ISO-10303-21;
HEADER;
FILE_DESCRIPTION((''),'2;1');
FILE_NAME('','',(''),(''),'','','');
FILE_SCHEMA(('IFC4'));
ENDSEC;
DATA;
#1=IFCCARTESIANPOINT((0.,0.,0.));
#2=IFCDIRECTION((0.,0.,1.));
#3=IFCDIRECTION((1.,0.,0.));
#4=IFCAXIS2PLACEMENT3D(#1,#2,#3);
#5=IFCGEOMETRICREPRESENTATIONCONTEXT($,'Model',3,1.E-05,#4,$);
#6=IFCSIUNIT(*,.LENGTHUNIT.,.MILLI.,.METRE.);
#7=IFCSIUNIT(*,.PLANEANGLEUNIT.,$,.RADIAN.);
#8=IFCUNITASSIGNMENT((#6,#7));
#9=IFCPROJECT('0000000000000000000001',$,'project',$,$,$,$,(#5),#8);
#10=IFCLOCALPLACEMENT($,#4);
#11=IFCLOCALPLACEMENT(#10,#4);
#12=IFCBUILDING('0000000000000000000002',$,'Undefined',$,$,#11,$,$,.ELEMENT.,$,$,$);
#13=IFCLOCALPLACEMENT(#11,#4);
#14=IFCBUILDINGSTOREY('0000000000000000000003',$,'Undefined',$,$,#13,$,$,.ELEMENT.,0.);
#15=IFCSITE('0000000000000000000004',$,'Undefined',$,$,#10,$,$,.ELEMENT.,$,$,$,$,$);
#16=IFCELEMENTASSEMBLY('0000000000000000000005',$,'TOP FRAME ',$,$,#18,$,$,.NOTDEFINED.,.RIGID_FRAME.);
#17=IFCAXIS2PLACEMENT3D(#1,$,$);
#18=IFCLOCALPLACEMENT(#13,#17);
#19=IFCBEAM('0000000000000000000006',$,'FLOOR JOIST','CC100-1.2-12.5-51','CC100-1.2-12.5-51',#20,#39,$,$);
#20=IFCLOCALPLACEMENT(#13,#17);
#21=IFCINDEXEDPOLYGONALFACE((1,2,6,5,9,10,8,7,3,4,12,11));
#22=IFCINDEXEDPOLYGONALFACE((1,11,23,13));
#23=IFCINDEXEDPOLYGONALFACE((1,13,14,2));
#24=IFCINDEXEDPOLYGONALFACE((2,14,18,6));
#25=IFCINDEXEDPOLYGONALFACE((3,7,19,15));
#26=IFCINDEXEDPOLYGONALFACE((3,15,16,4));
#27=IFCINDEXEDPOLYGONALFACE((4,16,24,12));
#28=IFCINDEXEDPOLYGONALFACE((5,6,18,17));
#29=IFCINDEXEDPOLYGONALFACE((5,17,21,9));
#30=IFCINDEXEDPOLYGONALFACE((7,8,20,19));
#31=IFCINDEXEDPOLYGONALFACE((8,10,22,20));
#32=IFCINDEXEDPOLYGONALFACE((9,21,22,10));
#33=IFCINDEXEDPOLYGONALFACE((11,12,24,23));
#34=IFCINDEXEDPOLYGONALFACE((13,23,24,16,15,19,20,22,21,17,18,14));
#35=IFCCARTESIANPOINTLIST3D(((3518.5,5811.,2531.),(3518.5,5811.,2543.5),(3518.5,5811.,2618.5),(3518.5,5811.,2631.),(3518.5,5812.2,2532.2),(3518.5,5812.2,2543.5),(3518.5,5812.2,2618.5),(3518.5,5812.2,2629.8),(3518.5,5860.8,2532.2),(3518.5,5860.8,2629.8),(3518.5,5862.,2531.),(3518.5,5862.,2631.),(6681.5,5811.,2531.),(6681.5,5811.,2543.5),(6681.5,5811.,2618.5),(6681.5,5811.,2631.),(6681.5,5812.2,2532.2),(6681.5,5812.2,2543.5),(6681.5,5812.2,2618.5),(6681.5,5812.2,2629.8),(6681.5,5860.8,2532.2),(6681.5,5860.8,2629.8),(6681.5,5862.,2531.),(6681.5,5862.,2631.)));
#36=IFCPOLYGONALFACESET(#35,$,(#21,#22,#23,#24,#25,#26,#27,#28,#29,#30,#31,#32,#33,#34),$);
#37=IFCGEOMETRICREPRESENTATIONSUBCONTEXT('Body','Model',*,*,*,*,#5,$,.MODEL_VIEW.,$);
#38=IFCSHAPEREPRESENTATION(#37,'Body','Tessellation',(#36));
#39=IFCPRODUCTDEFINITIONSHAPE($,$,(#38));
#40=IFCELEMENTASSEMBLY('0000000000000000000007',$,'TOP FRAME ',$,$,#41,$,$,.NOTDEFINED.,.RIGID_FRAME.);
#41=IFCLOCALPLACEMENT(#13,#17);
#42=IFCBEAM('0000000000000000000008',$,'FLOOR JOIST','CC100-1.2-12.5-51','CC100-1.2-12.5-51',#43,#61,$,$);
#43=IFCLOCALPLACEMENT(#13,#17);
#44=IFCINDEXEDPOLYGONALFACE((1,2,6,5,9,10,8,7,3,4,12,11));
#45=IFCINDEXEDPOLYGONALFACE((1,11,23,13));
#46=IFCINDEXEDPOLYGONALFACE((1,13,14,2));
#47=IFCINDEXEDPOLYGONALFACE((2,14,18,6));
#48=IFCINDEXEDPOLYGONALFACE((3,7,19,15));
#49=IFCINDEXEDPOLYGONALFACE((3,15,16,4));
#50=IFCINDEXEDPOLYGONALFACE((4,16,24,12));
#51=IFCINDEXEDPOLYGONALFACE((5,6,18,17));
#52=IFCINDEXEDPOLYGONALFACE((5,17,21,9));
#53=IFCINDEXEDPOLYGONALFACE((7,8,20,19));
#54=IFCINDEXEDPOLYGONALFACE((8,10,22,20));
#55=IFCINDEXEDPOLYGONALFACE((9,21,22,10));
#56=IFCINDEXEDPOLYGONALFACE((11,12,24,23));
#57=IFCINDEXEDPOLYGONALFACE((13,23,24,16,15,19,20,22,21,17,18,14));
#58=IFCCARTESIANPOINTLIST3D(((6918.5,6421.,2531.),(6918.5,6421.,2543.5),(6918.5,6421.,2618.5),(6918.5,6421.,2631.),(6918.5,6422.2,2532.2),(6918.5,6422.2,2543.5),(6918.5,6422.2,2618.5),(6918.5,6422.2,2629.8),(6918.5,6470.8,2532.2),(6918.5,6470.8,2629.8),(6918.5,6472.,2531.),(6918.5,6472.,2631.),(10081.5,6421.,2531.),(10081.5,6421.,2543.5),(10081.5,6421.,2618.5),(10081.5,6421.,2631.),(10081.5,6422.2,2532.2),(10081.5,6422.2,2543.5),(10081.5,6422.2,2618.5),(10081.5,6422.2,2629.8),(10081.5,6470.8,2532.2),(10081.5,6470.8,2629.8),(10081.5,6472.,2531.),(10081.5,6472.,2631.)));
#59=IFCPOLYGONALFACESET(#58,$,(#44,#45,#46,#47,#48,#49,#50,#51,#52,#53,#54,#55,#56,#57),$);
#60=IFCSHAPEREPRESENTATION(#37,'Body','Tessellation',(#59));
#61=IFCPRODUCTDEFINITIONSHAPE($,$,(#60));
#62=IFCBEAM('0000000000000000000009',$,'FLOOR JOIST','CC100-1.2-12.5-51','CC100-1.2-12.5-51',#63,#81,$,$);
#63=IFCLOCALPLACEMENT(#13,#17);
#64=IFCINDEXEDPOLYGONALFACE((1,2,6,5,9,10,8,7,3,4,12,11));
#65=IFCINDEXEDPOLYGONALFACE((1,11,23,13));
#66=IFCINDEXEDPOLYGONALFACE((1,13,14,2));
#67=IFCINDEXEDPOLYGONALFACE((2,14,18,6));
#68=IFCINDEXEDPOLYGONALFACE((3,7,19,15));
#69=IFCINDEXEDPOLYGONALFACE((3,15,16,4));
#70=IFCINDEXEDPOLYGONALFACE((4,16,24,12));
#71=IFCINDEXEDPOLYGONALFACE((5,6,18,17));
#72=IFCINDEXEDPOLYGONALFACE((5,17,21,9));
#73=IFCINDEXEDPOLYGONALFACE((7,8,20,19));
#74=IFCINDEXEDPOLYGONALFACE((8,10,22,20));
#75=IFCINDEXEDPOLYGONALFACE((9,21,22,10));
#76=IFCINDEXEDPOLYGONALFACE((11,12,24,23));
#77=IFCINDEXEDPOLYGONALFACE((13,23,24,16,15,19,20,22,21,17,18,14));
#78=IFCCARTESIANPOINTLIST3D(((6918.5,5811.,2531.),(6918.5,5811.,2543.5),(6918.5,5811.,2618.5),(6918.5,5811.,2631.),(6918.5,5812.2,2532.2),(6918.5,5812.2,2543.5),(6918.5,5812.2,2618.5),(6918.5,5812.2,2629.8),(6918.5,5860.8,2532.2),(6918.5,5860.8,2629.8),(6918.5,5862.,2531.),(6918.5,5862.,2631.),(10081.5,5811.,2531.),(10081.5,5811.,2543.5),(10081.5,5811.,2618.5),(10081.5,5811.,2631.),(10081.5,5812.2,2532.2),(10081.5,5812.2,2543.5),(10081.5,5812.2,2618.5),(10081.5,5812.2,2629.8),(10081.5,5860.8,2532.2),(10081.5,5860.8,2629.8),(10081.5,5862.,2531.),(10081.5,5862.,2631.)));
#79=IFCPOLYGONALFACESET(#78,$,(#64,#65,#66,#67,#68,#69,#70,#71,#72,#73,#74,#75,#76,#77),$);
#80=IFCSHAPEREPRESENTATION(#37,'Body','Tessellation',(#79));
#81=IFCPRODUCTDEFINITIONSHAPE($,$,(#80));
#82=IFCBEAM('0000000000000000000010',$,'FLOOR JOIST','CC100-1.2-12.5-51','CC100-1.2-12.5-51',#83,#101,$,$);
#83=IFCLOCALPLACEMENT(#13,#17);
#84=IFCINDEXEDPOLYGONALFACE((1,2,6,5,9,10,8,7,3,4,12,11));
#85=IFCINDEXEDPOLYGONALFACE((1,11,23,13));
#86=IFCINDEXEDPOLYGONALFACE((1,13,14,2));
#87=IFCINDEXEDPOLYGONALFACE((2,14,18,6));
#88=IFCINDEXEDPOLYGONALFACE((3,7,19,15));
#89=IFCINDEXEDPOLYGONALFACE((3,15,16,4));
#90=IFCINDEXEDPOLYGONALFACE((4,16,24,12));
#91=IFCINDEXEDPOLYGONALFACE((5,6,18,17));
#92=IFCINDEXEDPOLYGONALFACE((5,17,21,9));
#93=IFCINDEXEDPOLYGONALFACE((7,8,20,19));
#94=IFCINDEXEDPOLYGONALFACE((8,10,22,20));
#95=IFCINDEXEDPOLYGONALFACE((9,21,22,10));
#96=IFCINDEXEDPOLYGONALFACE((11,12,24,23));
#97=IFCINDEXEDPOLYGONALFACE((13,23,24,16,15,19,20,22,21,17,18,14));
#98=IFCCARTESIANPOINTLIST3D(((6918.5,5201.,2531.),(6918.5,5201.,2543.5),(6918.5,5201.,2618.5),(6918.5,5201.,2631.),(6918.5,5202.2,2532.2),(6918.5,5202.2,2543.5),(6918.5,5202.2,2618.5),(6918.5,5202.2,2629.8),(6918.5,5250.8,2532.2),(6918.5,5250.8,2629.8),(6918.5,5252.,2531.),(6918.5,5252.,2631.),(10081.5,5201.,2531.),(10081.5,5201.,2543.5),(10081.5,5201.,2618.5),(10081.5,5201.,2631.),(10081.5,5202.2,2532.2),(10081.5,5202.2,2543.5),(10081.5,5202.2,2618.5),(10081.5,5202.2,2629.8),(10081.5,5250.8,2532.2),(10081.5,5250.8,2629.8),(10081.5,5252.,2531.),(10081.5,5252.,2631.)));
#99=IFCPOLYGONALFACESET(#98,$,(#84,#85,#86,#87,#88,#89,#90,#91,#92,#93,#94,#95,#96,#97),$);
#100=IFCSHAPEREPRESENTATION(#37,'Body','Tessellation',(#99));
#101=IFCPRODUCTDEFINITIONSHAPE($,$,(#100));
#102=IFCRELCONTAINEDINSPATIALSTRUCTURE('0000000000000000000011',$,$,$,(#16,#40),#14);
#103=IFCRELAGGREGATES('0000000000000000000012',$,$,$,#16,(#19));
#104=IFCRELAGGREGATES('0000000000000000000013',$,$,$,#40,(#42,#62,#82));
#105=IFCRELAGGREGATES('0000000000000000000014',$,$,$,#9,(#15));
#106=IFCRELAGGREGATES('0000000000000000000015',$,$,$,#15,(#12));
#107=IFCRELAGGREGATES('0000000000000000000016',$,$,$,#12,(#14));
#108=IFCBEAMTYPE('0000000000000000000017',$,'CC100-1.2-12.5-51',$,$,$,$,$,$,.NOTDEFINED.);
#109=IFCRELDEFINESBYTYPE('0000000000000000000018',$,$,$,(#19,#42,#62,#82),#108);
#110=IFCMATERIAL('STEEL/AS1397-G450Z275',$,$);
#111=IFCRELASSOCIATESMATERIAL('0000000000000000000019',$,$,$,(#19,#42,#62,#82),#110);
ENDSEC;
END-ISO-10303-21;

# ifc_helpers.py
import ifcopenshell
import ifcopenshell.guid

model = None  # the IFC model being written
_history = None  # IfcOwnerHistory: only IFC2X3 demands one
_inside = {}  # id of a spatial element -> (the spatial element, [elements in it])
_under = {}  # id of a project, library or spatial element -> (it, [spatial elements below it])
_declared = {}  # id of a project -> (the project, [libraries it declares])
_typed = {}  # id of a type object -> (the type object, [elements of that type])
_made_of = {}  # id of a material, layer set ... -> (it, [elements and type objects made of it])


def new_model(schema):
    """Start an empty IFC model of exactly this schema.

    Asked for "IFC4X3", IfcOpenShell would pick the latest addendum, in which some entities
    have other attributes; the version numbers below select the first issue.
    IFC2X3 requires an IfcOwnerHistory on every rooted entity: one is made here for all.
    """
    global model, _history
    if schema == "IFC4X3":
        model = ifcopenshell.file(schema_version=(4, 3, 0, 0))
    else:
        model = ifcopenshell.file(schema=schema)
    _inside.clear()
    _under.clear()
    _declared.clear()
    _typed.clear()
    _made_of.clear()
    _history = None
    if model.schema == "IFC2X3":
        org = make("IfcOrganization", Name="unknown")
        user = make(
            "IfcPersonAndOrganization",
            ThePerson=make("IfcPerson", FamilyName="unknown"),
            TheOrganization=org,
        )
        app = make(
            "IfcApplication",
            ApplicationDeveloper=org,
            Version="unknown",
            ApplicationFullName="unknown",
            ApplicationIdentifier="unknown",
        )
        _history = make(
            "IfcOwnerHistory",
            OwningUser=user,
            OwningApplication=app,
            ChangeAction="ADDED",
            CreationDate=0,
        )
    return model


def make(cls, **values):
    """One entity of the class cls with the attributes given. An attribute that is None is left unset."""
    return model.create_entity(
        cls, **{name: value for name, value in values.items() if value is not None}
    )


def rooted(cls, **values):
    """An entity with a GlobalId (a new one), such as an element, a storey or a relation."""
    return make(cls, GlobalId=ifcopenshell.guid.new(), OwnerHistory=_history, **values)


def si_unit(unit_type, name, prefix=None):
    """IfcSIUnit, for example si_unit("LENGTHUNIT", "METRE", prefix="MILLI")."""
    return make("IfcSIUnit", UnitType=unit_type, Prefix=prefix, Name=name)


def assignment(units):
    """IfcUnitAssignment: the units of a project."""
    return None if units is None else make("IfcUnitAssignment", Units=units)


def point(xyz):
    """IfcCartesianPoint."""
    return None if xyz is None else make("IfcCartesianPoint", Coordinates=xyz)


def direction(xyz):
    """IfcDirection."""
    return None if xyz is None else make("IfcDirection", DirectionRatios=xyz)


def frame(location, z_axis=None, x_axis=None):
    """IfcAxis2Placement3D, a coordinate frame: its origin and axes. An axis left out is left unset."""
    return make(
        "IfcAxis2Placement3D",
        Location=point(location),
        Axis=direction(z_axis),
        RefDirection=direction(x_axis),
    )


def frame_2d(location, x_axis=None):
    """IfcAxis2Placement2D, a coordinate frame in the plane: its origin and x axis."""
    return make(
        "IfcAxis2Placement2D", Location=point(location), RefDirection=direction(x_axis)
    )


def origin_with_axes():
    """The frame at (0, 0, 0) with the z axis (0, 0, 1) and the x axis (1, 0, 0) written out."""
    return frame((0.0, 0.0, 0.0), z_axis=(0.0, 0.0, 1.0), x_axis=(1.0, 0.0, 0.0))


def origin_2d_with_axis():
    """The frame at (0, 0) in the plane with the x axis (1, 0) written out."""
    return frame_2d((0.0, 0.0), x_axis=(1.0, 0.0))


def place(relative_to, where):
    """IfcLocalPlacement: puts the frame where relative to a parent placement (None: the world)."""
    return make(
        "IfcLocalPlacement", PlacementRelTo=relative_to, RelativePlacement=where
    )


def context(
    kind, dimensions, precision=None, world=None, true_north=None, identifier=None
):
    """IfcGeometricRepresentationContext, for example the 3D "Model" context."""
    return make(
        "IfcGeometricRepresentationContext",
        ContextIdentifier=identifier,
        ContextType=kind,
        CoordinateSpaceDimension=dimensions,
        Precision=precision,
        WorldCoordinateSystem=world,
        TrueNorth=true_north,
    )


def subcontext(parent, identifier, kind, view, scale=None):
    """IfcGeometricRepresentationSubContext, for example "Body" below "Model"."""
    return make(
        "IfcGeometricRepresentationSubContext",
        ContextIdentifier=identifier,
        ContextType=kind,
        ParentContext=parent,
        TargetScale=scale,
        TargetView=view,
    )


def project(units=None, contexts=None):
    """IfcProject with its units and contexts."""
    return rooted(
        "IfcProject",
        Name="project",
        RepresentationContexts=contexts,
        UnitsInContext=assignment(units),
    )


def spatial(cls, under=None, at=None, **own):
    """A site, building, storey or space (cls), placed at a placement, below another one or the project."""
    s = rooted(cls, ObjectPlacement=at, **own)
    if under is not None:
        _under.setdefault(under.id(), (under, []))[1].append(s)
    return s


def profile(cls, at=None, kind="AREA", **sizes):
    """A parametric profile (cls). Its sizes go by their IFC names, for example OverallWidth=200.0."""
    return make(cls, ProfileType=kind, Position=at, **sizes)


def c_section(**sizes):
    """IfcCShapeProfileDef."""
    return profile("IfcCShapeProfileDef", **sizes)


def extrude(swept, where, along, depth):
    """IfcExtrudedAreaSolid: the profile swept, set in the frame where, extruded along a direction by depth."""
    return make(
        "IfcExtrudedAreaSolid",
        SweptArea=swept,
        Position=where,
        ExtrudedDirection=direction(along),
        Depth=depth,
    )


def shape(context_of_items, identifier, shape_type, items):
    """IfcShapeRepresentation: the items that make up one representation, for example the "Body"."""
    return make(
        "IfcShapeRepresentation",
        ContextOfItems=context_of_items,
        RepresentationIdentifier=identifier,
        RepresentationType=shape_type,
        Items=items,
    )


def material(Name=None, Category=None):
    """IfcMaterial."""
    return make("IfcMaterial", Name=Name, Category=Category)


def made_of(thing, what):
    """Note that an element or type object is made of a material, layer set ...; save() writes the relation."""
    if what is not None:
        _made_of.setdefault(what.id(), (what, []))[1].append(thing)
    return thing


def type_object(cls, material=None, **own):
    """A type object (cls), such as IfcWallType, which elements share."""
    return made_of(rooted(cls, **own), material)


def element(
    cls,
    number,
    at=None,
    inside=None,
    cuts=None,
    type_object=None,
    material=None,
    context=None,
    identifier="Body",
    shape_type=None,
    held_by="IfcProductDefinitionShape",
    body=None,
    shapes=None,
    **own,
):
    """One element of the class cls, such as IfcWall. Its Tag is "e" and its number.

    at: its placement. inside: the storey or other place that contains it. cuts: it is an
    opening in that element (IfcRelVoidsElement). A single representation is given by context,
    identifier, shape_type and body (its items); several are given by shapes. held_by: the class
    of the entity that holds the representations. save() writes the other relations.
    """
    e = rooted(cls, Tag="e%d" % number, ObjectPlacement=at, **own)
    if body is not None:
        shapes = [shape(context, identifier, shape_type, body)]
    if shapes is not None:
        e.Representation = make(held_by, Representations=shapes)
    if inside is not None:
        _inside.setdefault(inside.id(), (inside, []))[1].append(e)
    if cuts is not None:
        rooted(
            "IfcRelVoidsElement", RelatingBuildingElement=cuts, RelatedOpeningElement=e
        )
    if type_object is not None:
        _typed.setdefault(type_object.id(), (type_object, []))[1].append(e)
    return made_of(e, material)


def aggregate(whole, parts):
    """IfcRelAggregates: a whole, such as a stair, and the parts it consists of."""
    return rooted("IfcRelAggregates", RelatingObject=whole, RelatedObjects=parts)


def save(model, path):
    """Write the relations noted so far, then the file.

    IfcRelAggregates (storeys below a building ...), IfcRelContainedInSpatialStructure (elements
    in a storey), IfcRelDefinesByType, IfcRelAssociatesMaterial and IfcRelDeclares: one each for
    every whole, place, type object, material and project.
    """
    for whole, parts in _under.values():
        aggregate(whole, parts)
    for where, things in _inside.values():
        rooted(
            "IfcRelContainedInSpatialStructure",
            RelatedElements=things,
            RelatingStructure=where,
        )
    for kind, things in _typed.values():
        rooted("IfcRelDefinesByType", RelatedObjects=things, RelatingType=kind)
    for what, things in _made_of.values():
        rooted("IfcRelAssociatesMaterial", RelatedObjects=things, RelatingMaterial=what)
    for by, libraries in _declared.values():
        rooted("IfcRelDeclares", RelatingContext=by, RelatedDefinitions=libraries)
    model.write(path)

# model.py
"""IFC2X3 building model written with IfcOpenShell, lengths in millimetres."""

from ifc_helpers import new_model, si_unit, frame, origin_with_axes, origin_2d_with_axis, place, context, subcontext, project, spatial, c_section, extrude, material, type_object, element, aggregate, save


model = new_model("IFC2X3")

# Units and contexts
model_context = context("Model", 3, precision=1e-05, world=origin_with_axes())
body_context = subcontext(model_context, "Body", "Model", "MODEL_VIEW")
ifc_project = project(units=[si_unit("LENGTHUNIT", "METRE", prefix="MILLI"), si_unit("PLANEANGLEUNIT", "RADIAN")], contexts=[model_context])

# Site, building, storey
site_placement = place(None, origin_with_axes())
site = spatial("IfcSite", under=ifc_project, at=site_placement, Name="Undefined", CompositionType="ELEMENT")
building_placement = place(site_placement, origin_with_axes())
building = spatial("IfcBuilding", under=site, at=building_placement, Name="Undefined", CompositionType="ELEMENT")
storey_placement = place(building_placement, origin_with_axes())
storey = spatial("IfcBuildingStorey", under=building, at=storey_placement, Name="Undefined", CompositionType="ELEMENT", Elevation=0.0)

# Element assemblies, beams
ifc_material_1 = material(Name="STEEL/AS1397-G450Z275")
assembly_1_placement = place(storey_placement, origin_with_axes())
assembly_1 = element("IfcElementAssembly", 1, at=assembly_1_placement, inside=storey, Name="TOP FRAME ", AssemblyPlace="NOTDEFINED", PredefinedType="RIGID_FRAME")
beam_type_1 = type_object("IfcBeamType", Name="CC100-1.2-12.5-51", PredefinedType="NOTDEFINED")
beam_1_placement = place(assembly_1_placement, frame((3518.5, 5836.5, 2581.0), z_axis=(0.0, 0.0, 1.0), x_axis=(1.0, 0.0, 0.0)))
beam_1 = element("IfcBeam", 2, at=beam_1_placement, type_object=beam_type_1, material=ifc_material_1, Name="FLOOR JOIST", Description="CC100-1.2-12.5-51", ObjectType="CC100-1.2-12.5-51", context=body_context, shape_type="SweptSolid", body=[
    extrude(c_section(Depth=100.0, Width=51.0, WallThickness=1.2, Girth=12.5, at=origin_2d_with_axis()), frame((3163.0, 0.0, 0.0), z_axis=(-1.0, 0.0, 0.0), x_axis=(0.0, -1.0, 0.0)), (0.0, 0.0, 1.0), 3163.0),
])
assembly_2_placement = place(storey_placement, origin_with_axes())
assembly_2 = element("IfcElementAssembly", 3, at=assembly_2_placement, inside=storey, Name="TOP FRAME ", AssemblyPlace="NOTDEFINED", PredefinedType="RIGID_FRAME")
beam_2_placement = place(assembly_2_placement, frame((6918.5, 6446.5, 2581.0), z_axis=(0.0, 0.0, 1.0), x_axis=(1.0, 0.0, 0.0)))
beam_2 = element("IfcBeam", 4, at=beam_2_placement, type_object=beam_type_1, material=ifc_material_1, Name="FLOOR JOIST", Description="CC100-1.2-12.5-51", ObjectType="CC100-1.2-12.5-51", context=body_context, shape_type="SweptSolid", body=[
    extrude(c_section(Depth=100.0, Width=51.0, WallThickness=1.2, Girth=12.5, at=origin_2d_with_axis()), frame((3163.0, 0.0, 0.0), z_axis=(-1.0, 0.0, 0.0), x_axis=(0.0, -1.0, 0.0)), (0.0, 0.0, 1.0), 3163.0),
])
beam_3_placement = place(assembly_2_placement, frame((6918.5, 5836.5, 2581.0), z_axis=(0.0, 0.0, 1.0), x_axis=(1.0, 0.0, 0.0)))
beam_3 = element("IfcBeam", 5, at=beam_3_placement, type_object=beam_type_1, material=ifc_material_1, Name="FLOOR JOIST", Description="CC100-1.2-12.5-51", ObjectType="CC100-1.2-12.5-51", context=body_context, shape_type="SweptSolid", body=[
    extrude(c_section(Depth=100.0, Width=51.0, WallThickness=1.2, Girth=12.5, at=origin_2d_with_axis()), frame((3163.0, 0.0, 0.0), z_axis=(-1.0, 0.0, 0.0), x_axis=(0.0, -1.0, 0.0)), (0.0, 0.0, 1.0), 3163.0),
])
beam_4_placement = place(assembly_2_placement, frame((6918.5, 5226.5, 2581.0), z_axis=(0.0, 0.0, 1.0), x_axis=(1.0, 0.0, 0.0)))
beam_4 = element("IfcBeam", 6, at=beam_4_placement, type_object=beam_type_1, material=ifc_material_1, Name="FLOOR JOIST", Description="CC100-1.2-12.5-51", ObjectType="CC100-1.2-12.5-51", context=body_context, shape_type="SweptSolid", body=[
    extrude(c_section(Depth=100.0, Width=51.0, WallThickness=1.2, Girth=12.5, at=origin_2d_with_axis()), frame((3163.0, 0.0, 0.0), z_axis=(-1.0, 0.0, 0.0), x_axis=(0.0, -1.0, 0.0)), (0.0, 0.0, 1.0), 3163.0),
])

aggregate(assembly_1, [beam_1])
aggregate(assembly_2, [beam_2, beam_3, beam_4])

save(model, "model.ifc")
